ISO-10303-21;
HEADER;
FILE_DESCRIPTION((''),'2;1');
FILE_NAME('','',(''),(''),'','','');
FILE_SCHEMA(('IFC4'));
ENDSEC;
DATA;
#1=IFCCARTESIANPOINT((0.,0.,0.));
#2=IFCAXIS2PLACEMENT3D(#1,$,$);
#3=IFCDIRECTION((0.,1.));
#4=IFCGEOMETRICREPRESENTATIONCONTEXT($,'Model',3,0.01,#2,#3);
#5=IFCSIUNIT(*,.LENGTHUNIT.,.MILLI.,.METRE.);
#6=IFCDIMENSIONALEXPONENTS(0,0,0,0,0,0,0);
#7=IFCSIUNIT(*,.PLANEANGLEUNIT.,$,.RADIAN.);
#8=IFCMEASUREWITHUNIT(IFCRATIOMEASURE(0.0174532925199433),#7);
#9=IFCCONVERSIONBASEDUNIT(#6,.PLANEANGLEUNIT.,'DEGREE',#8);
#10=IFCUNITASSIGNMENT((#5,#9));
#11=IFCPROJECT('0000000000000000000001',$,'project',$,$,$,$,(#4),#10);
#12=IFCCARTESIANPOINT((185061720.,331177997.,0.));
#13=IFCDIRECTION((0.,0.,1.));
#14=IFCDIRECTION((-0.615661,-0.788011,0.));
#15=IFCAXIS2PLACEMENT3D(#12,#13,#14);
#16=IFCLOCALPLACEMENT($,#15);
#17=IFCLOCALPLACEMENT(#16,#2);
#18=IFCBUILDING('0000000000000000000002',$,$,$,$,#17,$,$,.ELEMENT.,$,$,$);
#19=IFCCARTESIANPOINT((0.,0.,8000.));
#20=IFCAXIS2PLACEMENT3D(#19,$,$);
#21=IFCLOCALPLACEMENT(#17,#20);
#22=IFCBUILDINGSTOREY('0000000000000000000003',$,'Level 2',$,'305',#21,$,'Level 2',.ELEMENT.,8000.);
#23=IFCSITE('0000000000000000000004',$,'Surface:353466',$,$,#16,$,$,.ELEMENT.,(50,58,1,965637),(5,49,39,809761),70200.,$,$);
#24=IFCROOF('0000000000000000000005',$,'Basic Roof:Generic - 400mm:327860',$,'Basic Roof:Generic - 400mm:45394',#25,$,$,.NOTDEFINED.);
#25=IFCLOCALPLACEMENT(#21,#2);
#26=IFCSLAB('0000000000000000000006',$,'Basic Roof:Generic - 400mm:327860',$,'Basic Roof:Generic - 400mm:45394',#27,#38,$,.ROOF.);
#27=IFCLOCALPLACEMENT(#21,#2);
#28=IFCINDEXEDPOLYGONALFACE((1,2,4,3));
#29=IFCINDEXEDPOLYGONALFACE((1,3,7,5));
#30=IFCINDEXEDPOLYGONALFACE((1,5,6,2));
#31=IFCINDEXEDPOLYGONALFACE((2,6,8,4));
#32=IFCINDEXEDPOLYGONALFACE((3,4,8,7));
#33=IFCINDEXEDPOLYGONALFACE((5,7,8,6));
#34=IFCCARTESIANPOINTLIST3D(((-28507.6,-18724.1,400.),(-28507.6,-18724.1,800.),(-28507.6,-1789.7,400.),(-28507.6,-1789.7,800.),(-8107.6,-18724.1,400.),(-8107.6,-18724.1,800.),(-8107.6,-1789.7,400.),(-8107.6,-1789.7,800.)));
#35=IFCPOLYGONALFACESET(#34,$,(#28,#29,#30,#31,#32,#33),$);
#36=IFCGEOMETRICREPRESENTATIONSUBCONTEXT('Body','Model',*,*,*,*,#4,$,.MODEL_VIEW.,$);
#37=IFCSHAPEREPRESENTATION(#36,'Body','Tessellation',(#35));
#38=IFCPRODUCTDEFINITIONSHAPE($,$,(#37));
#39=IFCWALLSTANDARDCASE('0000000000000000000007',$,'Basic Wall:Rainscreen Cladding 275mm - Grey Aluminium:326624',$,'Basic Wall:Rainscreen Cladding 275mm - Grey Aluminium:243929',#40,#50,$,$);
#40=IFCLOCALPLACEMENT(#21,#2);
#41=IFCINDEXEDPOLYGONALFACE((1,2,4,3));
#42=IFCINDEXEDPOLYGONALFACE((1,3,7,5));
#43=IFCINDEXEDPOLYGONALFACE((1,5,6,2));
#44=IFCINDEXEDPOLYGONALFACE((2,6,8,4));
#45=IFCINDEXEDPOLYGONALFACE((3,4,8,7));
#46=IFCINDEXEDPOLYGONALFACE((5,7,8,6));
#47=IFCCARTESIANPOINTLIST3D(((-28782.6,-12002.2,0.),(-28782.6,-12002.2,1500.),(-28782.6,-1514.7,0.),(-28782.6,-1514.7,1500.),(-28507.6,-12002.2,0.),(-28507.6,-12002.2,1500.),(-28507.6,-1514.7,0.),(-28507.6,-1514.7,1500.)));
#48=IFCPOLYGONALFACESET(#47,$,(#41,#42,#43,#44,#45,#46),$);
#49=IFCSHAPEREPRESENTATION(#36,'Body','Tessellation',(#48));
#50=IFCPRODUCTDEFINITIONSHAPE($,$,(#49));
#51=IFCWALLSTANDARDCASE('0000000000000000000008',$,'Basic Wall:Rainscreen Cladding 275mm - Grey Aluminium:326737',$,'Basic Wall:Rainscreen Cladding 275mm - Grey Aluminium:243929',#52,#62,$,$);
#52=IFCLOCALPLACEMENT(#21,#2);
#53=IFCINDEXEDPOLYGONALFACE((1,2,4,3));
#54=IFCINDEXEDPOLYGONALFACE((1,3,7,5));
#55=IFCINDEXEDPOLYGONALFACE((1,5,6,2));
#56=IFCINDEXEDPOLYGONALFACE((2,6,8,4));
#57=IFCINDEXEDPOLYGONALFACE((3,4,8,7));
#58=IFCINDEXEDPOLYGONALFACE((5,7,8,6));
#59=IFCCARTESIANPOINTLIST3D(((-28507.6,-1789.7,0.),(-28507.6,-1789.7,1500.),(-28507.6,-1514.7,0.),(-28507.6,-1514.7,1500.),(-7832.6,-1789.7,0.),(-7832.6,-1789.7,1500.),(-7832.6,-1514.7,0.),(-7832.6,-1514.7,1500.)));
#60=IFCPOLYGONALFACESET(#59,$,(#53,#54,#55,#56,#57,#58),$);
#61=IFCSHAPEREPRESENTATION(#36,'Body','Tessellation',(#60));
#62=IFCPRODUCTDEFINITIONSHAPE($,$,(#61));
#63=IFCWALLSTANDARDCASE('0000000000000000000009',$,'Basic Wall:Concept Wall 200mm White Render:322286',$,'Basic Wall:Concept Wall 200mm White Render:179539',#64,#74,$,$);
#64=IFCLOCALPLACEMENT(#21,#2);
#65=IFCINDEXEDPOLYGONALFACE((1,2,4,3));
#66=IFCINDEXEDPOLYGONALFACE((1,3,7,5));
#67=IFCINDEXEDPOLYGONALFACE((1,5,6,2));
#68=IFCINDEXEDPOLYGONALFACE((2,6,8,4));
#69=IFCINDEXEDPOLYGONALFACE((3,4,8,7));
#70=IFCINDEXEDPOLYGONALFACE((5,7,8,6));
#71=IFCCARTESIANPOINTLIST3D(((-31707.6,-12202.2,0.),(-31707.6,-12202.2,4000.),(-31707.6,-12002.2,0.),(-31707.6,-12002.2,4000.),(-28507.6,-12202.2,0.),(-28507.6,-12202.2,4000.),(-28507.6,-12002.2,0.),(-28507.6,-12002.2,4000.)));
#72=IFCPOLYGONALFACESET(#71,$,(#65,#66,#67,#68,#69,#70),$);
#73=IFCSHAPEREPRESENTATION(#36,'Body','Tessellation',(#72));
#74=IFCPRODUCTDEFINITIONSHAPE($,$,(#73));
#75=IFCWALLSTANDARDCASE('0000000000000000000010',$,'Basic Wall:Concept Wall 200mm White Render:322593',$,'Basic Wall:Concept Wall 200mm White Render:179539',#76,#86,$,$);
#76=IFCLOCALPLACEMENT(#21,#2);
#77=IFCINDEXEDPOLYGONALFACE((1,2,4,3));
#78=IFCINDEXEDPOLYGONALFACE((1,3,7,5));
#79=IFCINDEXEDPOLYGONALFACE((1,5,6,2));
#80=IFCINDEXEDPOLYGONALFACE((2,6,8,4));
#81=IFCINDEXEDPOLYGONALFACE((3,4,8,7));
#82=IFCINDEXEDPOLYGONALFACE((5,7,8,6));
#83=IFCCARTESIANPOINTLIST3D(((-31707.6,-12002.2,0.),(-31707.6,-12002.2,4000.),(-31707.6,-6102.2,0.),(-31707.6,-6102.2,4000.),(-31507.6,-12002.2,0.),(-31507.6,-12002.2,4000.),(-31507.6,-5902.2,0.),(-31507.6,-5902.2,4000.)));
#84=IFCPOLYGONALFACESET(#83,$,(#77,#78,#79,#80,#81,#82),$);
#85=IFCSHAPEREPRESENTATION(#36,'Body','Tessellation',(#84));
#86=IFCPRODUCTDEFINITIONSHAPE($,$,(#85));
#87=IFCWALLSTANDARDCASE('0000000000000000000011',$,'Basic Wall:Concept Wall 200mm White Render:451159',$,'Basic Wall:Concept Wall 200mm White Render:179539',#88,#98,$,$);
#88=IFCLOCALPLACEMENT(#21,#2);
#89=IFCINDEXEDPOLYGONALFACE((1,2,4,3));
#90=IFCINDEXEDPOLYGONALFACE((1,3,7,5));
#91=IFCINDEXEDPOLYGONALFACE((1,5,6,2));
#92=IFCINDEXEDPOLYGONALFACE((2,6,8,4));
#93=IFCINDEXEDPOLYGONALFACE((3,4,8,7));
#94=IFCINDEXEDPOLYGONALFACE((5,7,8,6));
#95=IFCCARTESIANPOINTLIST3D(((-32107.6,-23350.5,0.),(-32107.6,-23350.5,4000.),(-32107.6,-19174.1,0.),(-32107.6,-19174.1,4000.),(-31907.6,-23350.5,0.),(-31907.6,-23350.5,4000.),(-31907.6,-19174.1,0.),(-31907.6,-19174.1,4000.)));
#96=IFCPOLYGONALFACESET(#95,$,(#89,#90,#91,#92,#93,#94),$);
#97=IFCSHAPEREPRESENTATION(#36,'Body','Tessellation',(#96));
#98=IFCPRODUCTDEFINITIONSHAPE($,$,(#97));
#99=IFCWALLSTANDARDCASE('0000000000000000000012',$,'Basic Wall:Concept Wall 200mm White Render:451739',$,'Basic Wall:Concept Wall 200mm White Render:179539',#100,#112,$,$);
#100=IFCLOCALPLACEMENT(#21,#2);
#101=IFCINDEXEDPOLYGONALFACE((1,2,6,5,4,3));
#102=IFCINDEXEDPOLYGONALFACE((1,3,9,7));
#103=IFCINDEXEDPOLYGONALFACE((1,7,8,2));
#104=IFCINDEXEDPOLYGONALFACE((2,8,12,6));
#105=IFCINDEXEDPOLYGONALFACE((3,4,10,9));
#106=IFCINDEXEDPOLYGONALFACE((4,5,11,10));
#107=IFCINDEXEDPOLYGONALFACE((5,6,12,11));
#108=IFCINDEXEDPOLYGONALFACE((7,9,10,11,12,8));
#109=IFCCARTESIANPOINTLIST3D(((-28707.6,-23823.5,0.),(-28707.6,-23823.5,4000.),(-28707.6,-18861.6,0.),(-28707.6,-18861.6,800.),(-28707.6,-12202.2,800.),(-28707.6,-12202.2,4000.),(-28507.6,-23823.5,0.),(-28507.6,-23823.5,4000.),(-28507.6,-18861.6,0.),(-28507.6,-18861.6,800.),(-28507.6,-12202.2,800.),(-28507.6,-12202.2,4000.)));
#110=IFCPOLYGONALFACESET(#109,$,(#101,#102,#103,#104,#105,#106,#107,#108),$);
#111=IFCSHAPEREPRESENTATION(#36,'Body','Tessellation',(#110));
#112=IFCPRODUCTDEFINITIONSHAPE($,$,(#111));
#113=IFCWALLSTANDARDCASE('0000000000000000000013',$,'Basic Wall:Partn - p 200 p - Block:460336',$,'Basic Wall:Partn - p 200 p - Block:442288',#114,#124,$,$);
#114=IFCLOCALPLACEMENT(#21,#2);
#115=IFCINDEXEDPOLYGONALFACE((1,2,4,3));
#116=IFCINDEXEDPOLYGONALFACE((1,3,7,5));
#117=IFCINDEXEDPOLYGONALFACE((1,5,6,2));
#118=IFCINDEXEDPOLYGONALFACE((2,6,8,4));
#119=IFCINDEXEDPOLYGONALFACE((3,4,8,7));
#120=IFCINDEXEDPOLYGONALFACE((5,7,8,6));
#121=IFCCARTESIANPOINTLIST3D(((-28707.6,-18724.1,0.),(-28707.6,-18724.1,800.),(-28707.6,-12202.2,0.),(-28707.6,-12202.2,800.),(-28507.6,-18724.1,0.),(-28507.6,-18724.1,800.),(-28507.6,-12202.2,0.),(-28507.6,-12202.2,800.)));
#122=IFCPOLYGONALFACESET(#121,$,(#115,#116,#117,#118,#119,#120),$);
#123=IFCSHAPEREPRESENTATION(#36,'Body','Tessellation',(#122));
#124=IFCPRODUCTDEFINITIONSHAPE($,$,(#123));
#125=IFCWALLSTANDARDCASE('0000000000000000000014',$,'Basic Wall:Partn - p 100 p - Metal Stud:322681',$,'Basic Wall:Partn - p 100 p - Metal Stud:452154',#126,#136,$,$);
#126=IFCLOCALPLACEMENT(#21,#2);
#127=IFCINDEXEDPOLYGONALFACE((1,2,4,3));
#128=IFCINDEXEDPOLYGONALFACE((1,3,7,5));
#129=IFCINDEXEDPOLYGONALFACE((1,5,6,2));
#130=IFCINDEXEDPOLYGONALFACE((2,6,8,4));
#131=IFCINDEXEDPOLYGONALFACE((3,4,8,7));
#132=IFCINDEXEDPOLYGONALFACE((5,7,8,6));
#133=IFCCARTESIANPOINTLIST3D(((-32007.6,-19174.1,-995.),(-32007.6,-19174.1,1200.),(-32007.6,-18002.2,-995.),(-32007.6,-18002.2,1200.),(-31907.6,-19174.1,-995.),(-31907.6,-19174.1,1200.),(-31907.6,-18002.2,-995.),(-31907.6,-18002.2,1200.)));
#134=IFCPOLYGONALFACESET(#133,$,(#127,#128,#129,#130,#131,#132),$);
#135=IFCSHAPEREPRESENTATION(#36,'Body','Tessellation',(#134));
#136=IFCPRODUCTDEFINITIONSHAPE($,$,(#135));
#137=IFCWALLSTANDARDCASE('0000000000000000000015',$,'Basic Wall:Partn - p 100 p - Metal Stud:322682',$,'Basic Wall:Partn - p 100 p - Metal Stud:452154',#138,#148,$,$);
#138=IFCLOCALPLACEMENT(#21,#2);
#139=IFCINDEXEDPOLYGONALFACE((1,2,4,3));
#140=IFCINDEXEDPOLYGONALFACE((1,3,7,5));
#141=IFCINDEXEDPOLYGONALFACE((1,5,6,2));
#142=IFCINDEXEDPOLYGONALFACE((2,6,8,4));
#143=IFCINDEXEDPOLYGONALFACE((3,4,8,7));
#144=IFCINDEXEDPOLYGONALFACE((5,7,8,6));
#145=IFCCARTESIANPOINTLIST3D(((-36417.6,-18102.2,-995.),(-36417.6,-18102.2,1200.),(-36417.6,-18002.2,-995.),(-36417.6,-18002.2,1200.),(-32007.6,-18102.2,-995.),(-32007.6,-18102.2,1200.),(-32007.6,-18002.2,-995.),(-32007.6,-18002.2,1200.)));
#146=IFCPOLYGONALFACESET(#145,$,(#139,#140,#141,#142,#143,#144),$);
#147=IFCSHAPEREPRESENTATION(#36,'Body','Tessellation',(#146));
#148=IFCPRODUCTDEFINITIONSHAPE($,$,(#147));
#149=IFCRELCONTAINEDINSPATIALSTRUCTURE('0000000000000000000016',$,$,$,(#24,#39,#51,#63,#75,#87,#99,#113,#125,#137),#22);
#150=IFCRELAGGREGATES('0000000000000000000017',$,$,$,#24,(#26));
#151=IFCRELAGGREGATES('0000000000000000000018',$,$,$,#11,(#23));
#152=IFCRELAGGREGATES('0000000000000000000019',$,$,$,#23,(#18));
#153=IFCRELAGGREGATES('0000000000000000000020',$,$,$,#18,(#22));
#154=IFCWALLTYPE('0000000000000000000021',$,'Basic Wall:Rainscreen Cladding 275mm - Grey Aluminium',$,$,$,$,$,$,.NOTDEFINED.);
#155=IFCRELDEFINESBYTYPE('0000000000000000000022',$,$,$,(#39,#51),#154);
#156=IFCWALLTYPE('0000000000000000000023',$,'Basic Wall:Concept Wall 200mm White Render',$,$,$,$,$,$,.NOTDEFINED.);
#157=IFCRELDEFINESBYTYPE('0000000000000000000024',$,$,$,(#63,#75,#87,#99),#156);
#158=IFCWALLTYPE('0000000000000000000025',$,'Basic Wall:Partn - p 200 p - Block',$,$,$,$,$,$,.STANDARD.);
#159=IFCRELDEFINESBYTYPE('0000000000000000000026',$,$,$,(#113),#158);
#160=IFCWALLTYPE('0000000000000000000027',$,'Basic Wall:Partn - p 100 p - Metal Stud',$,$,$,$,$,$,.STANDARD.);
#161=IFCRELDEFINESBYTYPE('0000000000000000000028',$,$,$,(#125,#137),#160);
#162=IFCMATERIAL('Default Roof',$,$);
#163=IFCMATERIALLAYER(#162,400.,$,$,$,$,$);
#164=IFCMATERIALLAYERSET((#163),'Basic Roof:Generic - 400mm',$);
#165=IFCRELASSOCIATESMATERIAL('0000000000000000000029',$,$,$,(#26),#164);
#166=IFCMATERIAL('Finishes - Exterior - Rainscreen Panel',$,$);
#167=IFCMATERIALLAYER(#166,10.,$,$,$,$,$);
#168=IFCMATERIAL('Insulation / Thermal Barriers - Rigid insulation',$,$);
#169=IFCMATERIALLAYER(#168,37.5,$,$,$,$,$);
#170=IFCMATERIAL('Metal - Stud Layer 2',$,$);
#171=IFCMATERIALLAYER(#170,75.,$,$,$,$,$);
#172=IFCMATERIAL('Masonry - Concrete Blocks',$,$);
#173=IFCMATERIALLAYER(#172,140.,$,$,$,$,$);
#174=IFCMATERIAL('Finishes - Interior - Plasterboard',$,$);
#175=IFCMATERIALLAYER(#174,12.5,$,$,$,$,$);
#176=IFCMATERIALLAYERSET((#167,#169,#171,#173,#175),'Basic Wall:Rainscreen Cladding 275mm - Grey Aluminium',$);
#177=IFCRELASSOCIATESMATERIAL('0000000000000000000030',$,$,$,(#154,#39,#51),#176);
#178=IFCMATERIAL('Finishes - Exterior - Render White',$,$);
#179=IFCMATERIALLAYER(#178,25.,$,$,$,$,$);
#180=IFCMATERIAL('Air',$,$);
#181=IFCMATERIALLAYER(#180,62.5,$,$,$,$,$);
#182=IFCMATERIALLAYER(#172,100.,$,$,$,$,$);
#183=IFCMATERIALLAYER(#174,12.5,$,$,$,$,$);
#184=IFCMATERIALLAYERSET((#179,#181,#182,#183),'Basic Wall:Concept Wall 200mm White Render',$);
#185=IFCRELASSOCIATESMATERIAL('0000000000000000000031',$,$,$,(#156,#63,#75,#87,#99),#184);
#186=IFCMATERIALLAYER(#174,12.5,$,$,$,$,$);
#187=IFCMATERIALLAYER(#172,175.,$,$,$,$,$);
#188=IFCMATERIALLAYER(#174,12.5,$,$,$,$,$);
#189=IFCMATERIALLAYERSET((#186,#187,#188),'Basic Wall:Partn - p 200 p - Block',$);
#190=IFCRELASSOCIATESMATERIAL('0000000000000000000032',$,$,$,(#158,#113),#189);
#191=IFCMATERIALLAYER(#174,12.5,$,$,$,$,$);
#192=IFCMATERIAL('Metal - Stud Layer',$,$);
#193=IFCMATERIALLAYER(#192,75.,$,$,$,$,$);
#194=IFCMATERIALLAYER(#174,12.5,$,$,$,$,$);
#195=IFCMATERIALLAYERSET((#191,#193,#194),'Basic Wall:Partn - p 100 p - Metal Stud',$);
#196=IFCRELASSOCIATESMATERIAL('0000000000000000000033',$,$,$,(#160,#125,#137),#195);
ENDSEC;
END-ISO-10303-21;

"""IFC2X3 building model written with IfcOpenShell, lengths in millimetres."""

from ifc_helpers import new_model, entity, si_unit, converted_unit, direction, frame, frame_2d, origin, place, context, subcontext, project, spatial, polyline, rectangle, outline, extrude, clip, halfspace, material, layer, layer_set, layer_usage, type_object, element, aggregate, save


model = new_model("IFC2X3")

# Units and contexts
model_context = context("Model", 3, precision=0.01, world=origin(), true_north=direction((0.0, 1.0)))
body_context = subcontext(model_context, "Body", "Model", "MODEL_VIEW")
ifc_project = project(units=[si_unit("LENGTHUNIT", "METRE", prefix="MILLI"), converted_unit("PLANEANGLEUNIT", "DEGREE", entity("IfcRatioMeasure", 0.0174532925199433), si_unit("PLANEANGLEUNIT", "RADIAN"), dimensions=[0, 0, 0, 0, 0, 0, 0])], contexts=[model_context])

# Site, building, storey
site_placement = place(None, frame((185061720.0, 331177997.0, 0.0), z_axis=(0.0, 0.0, 1.0), x_axis=(-0.615661, -0.788011, 0.0)))
site = spatial("IfcSite", under=ifc_project, at=site_placement, Name="Surface:353466", CompositionType="ELEMENT", RefLatitude=(50, 58, 1, 965637), RefLongitude=(5, 49, 39, 809761), RefElevation=70200.0)
building_placement = place(site_placement, origin())
building = spatial("IfcBuilding", under=site, at=building_placement, CompositionType="ELEMENT")
storey_placement = place(building_placement, frame((0.0, 0.0, 8000.0)))
storey = spatial("IfcBuildingStorey", under=building, at=storey_placement, Name="Level 2", ObjectType="305", LongName="Level 2", CompositionType="ELEMENT", Elevation=8000.0)

# Roof, slab
roof_placement = place(storey_placement, frame((-28507.6, -18724.1, 400.0)))
roof = element("IfcRoof", 1, at=roof_placement, inside=storey, Name="Basic Roof:Generic - 400mm:327860", ObjectType="Basic Roof:Generic - 400mm:45394", ShapeType="NOTDEFINED")
ifc_material_1 = material(Name="Default Roof")
ifc_layer_1 = layer(ifc_material_1, 400.0)
ifc_layer_set_1 = layer_set([ifc_layer_1], Name="Basic Roof:Generic - 400mm")
slab_placement = place(roof_placement, origin())
slab = element("IfcSlab", 2, at=slab_placement, material=ifc_layer_set_1, Name="Basic Roof:Generic - 400mm:327860", ObjectType="Basic Roof:Generic - 400mm:45394", PredefinedType="ROOF", context=body_context, shape_type="SweptSolid", body=[
    extrude(rectangle(XDim=20400.0, YDim=16934.4, at=frame_2d((0.0, 0.0), x_axis=(1.0, 0.0))), frame((10200.0, 8467.2, 0.0)), (0.0, 0.0, 1.0), 400.0),
])
aggregate(roof, [slab])

# Walls
ifc_material_2 = material(Name="Finishes - Exterior - Rainscreen Panel")
ifc_layer_2 = layer(ifc_material_2, 10.0)
ifc_material_3 = material(Name="Insulation / Thermal Barriers - Rigid insulation")
ifc_layer_3 = layer(ifc_material_3, 37.5)
ifc_material_4 = material(Name="Metal - Stud Layer 2")
ifc_layer_4 = layer(ifc_material_4, 75.0)
ifc_material_5 = material(Name="Masonry - Concrete Blocks")
ifc_layer_5 = layer(ifc_material_5, 140.0)
ifc_material_6 = material(Name="Finishes - Interior - Plasterboard")
ifc_layer_6 = layer(ifc_material_6, 12.5)
ifc_layer_set_2 = layer_set([ifc_layer_2, ifc_layer_3, ifc_layer_4, ifc_layer_5, ifc_layer_6], Name="Basic Wall:Rainscreen Cladding 275mm - Grey Aluminium")
wall_type_1 = type_object("IfcWallType", Name="Basic Wall:Rainscreen Cladding 275mm - Grey Aluminium", PredefinedType="NOTDEFINED", material=ifc_layer_set_2)
ifc_layer_usage_1 = layer_usage(ifc_layer_set_2, "AXIS2", "NEGATIVE", 137.5)
wall_1_placement = place(storey_placement, frame((-28645.1, -12002.2, 0.0), z_axis=(0.0, 0.0, 1.0), x_axis=(0.0, 1.0, 0.0)))
element("IfcWallStandardCase", 3, at=wall_1_placement, inside=storey, type_object=wall_type_1, material=ifc_layer_usage_1, Name="Basic Wall:Rainscreen Cladding 275mm - Grey Aluminium:326624", ObjectType="Basic Wall:Rainscreen Cladding 275mm - Grey Aluminium:243929", context=body_context, shape_type="Clipping", body=[
    clip(extrude(rectangle(XDim=10487.5, YDim=275.0, at=frame_2d((5243.7, 0.0), x_axis=(-1.0, 0.0))), origin(), (0.0, 0.0, 1.0), 1500.0), halfspace(frame((0.0, 0.0, -8000.0)), True)),
])
ifc_layer_usage_2 = layer_usage(ifc_layer_set_2, "AXIS2", "NEGATIVE", 137.5)
wall_2_placement = place(storey_placement, frame((-28507.6, -1652.2, 0.0)))
element("IfcWallStandardCase", 4, at=wall_2_placement, inside=storey, type_object=wall_type_1, material=ifc_layer_usage_2, Name="Basic Wall:Rainscreen Cladding 275mm - Grey Aluminium:326737", ObjectType="Basic Wall:Rainscreen Cladding 275mm - Grey Aluminium:243929", context=body_context, shape_type="Clipping", body=[
    clip(extrude(rectangle(XDim=20675.0, YDim=275.0, at=frame_2d((10337.5, 0.0), x_axis=(-1.0, 0.0))), origin(), (0.0, 0.0, 1.0), 1500.0), halfspace(frame((0.0, 0.0, -8000.0)), True)),
])
ifc_material_7 = material(Name="Finishes - Exterior - Render White")
ifc_layer_7 = layer(ifc_material_7, 25.0)
ifc_material_8 = material(Name="Air")
ifc_layer_8 = layer(ifc_material_8, 62.5)
ifc_layer_9 = layer(ifc_material_5, 100.0)
ifc_layer_10 = layer(ifc_material_6, 12.5)
ifc_layer_set_3 = layer_set([ifc_layer_7, ifc_layer_8, ifc_layer_9, ifc_layer_10], Name="Basic Wall:Concept Wall 200mm White Render")
ifc_layer_usage_3 = layer_usage(ifc_layer_set_3, "AXIS2", "POSITIVE", -100.0)
wall_type_2 = type_object("IfcWallType", Name="Basic Wall:Concept Wall 200mm White Render", PredefinedType="NOTDEFINED", material=ifc_layer_set_3)
wall_3_placement = place(storey_placement, frame((-28507.6, -12102.2, 0.0), z_axis=(0.0, 0.0, 1.0), x_axis=(-1.0, 0.0, 0.0)))
element("IfcWallStandardCase", 5, at=wall_3_placement, inside=storey, type_object=wall_type_2, material=ifc_layer_usage_3, Name="Basic Wall:Concept Wall 200mm White Render:322286", ObjectType="Basic Wall:Concept Wall 200mm White Render:179539", context=body_context, shape_type="Clipping", body=[
    clip(extrude(rectangle(XDim=3200.0, YDim=200.0, at=frame_2d((1600.0, 0.0), x_axis=(-1.0, 0.0))), origin(), (0.0, 0.0, 1.0), 4000.0), halfspace(frame((0.0, 0.0, -8000.0)), True)),
])
ifc_layer_usage_4 = layer_usage(ifc_layer_set_3, "AXIS2", "POSITIVE", -100.0)
wall_4_placement = place(storey_placement, frame((-31607.6, -12002.2, 0.0), z_axis=(0.0, 0.0, 1.0), x_axis=(0.0, 1.0, 0.0)))
element("IfcWallStandardCase", 6, at=wall_4_placement, inside=storey, type_object=wall_type_2, material=ifc_layer_usage_4, Name="Basic Wall:Concept Wall 200mm White Render:322593", ObjectType="Basic Wall:Concept Wall 200mm White Render:179539", context=body_context, shape_type="Clipping", body=[
    clip(extrude(outline(polyline([(6100.0, -100.0), (5900.0, 100.0), (0.0, 100.0), (0.0, -100.0), (6100.0, -100.0)])), origin(), (0.0, 0.0, 1.0), 4000.0), halfspace(frame((0.0, 0.0, -8000.0)), True)),
])

# Wall
ifc_layer_usage_5 = layer_usage(ifc_layer_set_3, "AXIS2", "POSITIVE", -100.0)
wall_5_placement = place(storey_placement, frame((-32007.6, -19174.1, 0.0), z_axis=(0.0, 0.0, 1.0), x_axis=(0.0, -1.0, 0.0)))
element("IfcWallStandardCase", 7, at=wall_5_placement, inside=storey, type_object=wall_type_2, material=ifc_layer_usage_5, Name="Basic Wall:Concept Wall 200mm White Render:451159", ObjectType="Basic Wall:Concept Wall 200mm White Render:179539", context=body_context, shape_type="Clipping", body=[
    clip(extrude(rectangle(XDim=4176.4, YDim=200.0, at=frame_2d((2088.2, 0.0), x_axis=(-1.0, 0.0))), origin(), (0.0, 0.0, 1.0), 4000.0), halfspace(frame((0.0, 0.0, -4000.0)), True)),
])

# Wall, opening
ifc_layer_usage_6 = layer_usage(ifc_layer_set_3, "AXIS2", "POSITIVE", -100.0)
wall_6_placement = place(storey_placement, frame((-28607.6, -23823.5, 0.0), z_axis=(0.0, 0.0, 1.0), x_axis=(0.0, 1.0, 0.0)))
wall_6 = element("IfcWallStandardCase", 8, at=wall_6_placement, inside=storey, type_object=wall_type_2, material=ifc_layer_usage_6, Name="Basic Wall:Concept Wall 200mm White Render:451739", ObjectType="Basic Wall:Concept Wall 200mm White Render:179539", context=body_context, shape_type="Clipping", body=[
    clip(clip(extrude(rectangle(XDim=11621.2, YDim=200.0, at=frame_2d((5810.6, 0.0), x_axis=(-1.0, 0.0))), origin(), (0.0, 0.0, 1.0), 4000.0), halfspace(frame((4961.8, 0.0, 0.0), z_axis=(0.0, 0.0, -1.0), x_axis=(0.0, 1.0, 0.0)), False)), halfspace(frame((0.0, 0.0, -4000.0)), True)),
])
opening_1_placement = place(wall_6_placement, origin())
element("IfcOpeningElement", 9, at=opening_1_placement, cuts=wall_6, ObjectType="Opening", context=body_context, shape_type="SweptSolid", body=[
    extrude(rectangle(XDim=800.0, YDim=6759.4, at=frame_2d((0.0, 0.0), x_axis=(0.0, 1.0))), frame((8341.5, 100.0, 400.0), z_axis=(0.0, -1.0, 0.0), x_axis=(1.0, 0.0, 0.0)), (0.0, 0.0, 1.0), 200.0),
])

# Walls
ifc_layer_11 = layer(ifc_material_6, 12.5)
ifc_layer_12 = layer(ifc_material_5, 175.0)
ifc_layer_13 = layer(ifc_material_6, 12.5)
ifc_layer_set_4 = layer_set([ifc_layer_11, ifc_layer_12, ifc_layer_13], Name="Basic Wall:Partn - p 200 p - Block")
ifc_layer_usage_7 = layer_usage(ifc_layer_set_4, "AXIS2", "POSITIVE", -100.0)
wall_type_3 = type_object("IfcWallType", Name="Basic Wall:Partn - p 200 p - Block", PredefinedType="STANDARD", material=ifc_layer_set_4)
wall_7_placement = place(storey_placement, frame((-28607.6, -18724.1, 0.0), z_axis=(0.0, 0.0, 1.0), x_axis=(0.0, 1.0, 0.0)))
element("IfcWallStandardCase", 10, at=wall_7_placement, inside=storey, type_object=wall_type_3, material=ifc_layer_usage_7, Name="Basic Wall:Partn - p 200 p - Block:460336", ObjectType="Basic Wall:Partn - p 200 p - Block:442288", context=body_context, shape_type="Clipping", body=[
    clip(extrude(rectangle(XDim=6521.9, YDim=200.0, at=frame_2d((3261.0, 0.0), x_axis=(-1.0, 0.0))), origin(), (0.0, 0.0, 1.0), 800.0), halfspace(frame((0.0, 0.0, -4000.0)), True)),
])
ifc_layer_14 = layer(ifc_material_6, 12.5)
ifc_material_9 = material(Name="Metal - Stud Layer")
ifc_layer_15 = layer(ifc_material_9, 75.0)
ifc_layer_16 = layer(ifc_material_6, 12.5)
ifc_layer_set_5 = layer_set([ifc_layer_14, ifc_layer_15, ifc_layer_16], Name="Basic Wall:Partn - p 100 p - Metal Stud")
ifc_layer_usage_8 = layer_usage(ifc_layer_set_5, "AXIS2", "NEGATIVE", 50.0)
wall_type_4 = type_object("IfcWallType", Name="Basic Wall:Partn - p 100 p - Metal Stud", PredefinedType="STANDARD", material=ifc_layer_set_5)
wall_8_placement = place(storey_placement, frame((-31957.6, -19174.1, -995.0), z_axis=(0.0, 0.0, 1.0), x_axis=(0.0, 1.0, 0.0)))
element("IfcWallStandardCase", 11, at=wall_8_placement, inside=storey, type_object=wall_type_4, material=ifc_layer_usage_8, Name="Basic Wall:Partn - p 100 p - Metal Stud:322681", ObjectType="Basic Wall:Partn - p 100 p - Metal Stud:452154", context=body_context, shape_type="SweptSolid", body=[
    extrude(rectangle(XDim=1171.9, YDim=100.0, at=frame_2d((586.0, 0.0), x_axis=(-1.0, 0.0))), origin(), (0.0, 0.0, 1.0), 2195.0),
])
ifc_layer_usage_9 = layer_usage(ifc_layer_set_5, "AXIS2", "NEGATIVE", 50.0)
wall_9_placement = place(storey_placement, frame((-32007.6, -18052.2, -995.0), z_axis=(0.0, 0.0, 1.0), x_axis=(-1.0, 0.0, 0.0)))
element("IfcWallStandardCase", 12, at=wall_9_placement, inside=storey, type_object=wall_type_4, material=ifc_layer_usage_9, Name="Basic Wall:Partn - p 100 p - Metal Stud:322682", ObjectType="Basic Wall:Partn - p 100 p - Metal Stud:452154", context=body_context, shape_type="SweptSolid", body=[
    extrude(rectangle(XDim=4410.0, YDim=100.0, at=frame_2d((2205.0, 0.0), x_axis=(-1.0, 0.0))), origin(), (0.0, 0.0, 1.0), 2195.0),
])

save(model, "model.ifc")
